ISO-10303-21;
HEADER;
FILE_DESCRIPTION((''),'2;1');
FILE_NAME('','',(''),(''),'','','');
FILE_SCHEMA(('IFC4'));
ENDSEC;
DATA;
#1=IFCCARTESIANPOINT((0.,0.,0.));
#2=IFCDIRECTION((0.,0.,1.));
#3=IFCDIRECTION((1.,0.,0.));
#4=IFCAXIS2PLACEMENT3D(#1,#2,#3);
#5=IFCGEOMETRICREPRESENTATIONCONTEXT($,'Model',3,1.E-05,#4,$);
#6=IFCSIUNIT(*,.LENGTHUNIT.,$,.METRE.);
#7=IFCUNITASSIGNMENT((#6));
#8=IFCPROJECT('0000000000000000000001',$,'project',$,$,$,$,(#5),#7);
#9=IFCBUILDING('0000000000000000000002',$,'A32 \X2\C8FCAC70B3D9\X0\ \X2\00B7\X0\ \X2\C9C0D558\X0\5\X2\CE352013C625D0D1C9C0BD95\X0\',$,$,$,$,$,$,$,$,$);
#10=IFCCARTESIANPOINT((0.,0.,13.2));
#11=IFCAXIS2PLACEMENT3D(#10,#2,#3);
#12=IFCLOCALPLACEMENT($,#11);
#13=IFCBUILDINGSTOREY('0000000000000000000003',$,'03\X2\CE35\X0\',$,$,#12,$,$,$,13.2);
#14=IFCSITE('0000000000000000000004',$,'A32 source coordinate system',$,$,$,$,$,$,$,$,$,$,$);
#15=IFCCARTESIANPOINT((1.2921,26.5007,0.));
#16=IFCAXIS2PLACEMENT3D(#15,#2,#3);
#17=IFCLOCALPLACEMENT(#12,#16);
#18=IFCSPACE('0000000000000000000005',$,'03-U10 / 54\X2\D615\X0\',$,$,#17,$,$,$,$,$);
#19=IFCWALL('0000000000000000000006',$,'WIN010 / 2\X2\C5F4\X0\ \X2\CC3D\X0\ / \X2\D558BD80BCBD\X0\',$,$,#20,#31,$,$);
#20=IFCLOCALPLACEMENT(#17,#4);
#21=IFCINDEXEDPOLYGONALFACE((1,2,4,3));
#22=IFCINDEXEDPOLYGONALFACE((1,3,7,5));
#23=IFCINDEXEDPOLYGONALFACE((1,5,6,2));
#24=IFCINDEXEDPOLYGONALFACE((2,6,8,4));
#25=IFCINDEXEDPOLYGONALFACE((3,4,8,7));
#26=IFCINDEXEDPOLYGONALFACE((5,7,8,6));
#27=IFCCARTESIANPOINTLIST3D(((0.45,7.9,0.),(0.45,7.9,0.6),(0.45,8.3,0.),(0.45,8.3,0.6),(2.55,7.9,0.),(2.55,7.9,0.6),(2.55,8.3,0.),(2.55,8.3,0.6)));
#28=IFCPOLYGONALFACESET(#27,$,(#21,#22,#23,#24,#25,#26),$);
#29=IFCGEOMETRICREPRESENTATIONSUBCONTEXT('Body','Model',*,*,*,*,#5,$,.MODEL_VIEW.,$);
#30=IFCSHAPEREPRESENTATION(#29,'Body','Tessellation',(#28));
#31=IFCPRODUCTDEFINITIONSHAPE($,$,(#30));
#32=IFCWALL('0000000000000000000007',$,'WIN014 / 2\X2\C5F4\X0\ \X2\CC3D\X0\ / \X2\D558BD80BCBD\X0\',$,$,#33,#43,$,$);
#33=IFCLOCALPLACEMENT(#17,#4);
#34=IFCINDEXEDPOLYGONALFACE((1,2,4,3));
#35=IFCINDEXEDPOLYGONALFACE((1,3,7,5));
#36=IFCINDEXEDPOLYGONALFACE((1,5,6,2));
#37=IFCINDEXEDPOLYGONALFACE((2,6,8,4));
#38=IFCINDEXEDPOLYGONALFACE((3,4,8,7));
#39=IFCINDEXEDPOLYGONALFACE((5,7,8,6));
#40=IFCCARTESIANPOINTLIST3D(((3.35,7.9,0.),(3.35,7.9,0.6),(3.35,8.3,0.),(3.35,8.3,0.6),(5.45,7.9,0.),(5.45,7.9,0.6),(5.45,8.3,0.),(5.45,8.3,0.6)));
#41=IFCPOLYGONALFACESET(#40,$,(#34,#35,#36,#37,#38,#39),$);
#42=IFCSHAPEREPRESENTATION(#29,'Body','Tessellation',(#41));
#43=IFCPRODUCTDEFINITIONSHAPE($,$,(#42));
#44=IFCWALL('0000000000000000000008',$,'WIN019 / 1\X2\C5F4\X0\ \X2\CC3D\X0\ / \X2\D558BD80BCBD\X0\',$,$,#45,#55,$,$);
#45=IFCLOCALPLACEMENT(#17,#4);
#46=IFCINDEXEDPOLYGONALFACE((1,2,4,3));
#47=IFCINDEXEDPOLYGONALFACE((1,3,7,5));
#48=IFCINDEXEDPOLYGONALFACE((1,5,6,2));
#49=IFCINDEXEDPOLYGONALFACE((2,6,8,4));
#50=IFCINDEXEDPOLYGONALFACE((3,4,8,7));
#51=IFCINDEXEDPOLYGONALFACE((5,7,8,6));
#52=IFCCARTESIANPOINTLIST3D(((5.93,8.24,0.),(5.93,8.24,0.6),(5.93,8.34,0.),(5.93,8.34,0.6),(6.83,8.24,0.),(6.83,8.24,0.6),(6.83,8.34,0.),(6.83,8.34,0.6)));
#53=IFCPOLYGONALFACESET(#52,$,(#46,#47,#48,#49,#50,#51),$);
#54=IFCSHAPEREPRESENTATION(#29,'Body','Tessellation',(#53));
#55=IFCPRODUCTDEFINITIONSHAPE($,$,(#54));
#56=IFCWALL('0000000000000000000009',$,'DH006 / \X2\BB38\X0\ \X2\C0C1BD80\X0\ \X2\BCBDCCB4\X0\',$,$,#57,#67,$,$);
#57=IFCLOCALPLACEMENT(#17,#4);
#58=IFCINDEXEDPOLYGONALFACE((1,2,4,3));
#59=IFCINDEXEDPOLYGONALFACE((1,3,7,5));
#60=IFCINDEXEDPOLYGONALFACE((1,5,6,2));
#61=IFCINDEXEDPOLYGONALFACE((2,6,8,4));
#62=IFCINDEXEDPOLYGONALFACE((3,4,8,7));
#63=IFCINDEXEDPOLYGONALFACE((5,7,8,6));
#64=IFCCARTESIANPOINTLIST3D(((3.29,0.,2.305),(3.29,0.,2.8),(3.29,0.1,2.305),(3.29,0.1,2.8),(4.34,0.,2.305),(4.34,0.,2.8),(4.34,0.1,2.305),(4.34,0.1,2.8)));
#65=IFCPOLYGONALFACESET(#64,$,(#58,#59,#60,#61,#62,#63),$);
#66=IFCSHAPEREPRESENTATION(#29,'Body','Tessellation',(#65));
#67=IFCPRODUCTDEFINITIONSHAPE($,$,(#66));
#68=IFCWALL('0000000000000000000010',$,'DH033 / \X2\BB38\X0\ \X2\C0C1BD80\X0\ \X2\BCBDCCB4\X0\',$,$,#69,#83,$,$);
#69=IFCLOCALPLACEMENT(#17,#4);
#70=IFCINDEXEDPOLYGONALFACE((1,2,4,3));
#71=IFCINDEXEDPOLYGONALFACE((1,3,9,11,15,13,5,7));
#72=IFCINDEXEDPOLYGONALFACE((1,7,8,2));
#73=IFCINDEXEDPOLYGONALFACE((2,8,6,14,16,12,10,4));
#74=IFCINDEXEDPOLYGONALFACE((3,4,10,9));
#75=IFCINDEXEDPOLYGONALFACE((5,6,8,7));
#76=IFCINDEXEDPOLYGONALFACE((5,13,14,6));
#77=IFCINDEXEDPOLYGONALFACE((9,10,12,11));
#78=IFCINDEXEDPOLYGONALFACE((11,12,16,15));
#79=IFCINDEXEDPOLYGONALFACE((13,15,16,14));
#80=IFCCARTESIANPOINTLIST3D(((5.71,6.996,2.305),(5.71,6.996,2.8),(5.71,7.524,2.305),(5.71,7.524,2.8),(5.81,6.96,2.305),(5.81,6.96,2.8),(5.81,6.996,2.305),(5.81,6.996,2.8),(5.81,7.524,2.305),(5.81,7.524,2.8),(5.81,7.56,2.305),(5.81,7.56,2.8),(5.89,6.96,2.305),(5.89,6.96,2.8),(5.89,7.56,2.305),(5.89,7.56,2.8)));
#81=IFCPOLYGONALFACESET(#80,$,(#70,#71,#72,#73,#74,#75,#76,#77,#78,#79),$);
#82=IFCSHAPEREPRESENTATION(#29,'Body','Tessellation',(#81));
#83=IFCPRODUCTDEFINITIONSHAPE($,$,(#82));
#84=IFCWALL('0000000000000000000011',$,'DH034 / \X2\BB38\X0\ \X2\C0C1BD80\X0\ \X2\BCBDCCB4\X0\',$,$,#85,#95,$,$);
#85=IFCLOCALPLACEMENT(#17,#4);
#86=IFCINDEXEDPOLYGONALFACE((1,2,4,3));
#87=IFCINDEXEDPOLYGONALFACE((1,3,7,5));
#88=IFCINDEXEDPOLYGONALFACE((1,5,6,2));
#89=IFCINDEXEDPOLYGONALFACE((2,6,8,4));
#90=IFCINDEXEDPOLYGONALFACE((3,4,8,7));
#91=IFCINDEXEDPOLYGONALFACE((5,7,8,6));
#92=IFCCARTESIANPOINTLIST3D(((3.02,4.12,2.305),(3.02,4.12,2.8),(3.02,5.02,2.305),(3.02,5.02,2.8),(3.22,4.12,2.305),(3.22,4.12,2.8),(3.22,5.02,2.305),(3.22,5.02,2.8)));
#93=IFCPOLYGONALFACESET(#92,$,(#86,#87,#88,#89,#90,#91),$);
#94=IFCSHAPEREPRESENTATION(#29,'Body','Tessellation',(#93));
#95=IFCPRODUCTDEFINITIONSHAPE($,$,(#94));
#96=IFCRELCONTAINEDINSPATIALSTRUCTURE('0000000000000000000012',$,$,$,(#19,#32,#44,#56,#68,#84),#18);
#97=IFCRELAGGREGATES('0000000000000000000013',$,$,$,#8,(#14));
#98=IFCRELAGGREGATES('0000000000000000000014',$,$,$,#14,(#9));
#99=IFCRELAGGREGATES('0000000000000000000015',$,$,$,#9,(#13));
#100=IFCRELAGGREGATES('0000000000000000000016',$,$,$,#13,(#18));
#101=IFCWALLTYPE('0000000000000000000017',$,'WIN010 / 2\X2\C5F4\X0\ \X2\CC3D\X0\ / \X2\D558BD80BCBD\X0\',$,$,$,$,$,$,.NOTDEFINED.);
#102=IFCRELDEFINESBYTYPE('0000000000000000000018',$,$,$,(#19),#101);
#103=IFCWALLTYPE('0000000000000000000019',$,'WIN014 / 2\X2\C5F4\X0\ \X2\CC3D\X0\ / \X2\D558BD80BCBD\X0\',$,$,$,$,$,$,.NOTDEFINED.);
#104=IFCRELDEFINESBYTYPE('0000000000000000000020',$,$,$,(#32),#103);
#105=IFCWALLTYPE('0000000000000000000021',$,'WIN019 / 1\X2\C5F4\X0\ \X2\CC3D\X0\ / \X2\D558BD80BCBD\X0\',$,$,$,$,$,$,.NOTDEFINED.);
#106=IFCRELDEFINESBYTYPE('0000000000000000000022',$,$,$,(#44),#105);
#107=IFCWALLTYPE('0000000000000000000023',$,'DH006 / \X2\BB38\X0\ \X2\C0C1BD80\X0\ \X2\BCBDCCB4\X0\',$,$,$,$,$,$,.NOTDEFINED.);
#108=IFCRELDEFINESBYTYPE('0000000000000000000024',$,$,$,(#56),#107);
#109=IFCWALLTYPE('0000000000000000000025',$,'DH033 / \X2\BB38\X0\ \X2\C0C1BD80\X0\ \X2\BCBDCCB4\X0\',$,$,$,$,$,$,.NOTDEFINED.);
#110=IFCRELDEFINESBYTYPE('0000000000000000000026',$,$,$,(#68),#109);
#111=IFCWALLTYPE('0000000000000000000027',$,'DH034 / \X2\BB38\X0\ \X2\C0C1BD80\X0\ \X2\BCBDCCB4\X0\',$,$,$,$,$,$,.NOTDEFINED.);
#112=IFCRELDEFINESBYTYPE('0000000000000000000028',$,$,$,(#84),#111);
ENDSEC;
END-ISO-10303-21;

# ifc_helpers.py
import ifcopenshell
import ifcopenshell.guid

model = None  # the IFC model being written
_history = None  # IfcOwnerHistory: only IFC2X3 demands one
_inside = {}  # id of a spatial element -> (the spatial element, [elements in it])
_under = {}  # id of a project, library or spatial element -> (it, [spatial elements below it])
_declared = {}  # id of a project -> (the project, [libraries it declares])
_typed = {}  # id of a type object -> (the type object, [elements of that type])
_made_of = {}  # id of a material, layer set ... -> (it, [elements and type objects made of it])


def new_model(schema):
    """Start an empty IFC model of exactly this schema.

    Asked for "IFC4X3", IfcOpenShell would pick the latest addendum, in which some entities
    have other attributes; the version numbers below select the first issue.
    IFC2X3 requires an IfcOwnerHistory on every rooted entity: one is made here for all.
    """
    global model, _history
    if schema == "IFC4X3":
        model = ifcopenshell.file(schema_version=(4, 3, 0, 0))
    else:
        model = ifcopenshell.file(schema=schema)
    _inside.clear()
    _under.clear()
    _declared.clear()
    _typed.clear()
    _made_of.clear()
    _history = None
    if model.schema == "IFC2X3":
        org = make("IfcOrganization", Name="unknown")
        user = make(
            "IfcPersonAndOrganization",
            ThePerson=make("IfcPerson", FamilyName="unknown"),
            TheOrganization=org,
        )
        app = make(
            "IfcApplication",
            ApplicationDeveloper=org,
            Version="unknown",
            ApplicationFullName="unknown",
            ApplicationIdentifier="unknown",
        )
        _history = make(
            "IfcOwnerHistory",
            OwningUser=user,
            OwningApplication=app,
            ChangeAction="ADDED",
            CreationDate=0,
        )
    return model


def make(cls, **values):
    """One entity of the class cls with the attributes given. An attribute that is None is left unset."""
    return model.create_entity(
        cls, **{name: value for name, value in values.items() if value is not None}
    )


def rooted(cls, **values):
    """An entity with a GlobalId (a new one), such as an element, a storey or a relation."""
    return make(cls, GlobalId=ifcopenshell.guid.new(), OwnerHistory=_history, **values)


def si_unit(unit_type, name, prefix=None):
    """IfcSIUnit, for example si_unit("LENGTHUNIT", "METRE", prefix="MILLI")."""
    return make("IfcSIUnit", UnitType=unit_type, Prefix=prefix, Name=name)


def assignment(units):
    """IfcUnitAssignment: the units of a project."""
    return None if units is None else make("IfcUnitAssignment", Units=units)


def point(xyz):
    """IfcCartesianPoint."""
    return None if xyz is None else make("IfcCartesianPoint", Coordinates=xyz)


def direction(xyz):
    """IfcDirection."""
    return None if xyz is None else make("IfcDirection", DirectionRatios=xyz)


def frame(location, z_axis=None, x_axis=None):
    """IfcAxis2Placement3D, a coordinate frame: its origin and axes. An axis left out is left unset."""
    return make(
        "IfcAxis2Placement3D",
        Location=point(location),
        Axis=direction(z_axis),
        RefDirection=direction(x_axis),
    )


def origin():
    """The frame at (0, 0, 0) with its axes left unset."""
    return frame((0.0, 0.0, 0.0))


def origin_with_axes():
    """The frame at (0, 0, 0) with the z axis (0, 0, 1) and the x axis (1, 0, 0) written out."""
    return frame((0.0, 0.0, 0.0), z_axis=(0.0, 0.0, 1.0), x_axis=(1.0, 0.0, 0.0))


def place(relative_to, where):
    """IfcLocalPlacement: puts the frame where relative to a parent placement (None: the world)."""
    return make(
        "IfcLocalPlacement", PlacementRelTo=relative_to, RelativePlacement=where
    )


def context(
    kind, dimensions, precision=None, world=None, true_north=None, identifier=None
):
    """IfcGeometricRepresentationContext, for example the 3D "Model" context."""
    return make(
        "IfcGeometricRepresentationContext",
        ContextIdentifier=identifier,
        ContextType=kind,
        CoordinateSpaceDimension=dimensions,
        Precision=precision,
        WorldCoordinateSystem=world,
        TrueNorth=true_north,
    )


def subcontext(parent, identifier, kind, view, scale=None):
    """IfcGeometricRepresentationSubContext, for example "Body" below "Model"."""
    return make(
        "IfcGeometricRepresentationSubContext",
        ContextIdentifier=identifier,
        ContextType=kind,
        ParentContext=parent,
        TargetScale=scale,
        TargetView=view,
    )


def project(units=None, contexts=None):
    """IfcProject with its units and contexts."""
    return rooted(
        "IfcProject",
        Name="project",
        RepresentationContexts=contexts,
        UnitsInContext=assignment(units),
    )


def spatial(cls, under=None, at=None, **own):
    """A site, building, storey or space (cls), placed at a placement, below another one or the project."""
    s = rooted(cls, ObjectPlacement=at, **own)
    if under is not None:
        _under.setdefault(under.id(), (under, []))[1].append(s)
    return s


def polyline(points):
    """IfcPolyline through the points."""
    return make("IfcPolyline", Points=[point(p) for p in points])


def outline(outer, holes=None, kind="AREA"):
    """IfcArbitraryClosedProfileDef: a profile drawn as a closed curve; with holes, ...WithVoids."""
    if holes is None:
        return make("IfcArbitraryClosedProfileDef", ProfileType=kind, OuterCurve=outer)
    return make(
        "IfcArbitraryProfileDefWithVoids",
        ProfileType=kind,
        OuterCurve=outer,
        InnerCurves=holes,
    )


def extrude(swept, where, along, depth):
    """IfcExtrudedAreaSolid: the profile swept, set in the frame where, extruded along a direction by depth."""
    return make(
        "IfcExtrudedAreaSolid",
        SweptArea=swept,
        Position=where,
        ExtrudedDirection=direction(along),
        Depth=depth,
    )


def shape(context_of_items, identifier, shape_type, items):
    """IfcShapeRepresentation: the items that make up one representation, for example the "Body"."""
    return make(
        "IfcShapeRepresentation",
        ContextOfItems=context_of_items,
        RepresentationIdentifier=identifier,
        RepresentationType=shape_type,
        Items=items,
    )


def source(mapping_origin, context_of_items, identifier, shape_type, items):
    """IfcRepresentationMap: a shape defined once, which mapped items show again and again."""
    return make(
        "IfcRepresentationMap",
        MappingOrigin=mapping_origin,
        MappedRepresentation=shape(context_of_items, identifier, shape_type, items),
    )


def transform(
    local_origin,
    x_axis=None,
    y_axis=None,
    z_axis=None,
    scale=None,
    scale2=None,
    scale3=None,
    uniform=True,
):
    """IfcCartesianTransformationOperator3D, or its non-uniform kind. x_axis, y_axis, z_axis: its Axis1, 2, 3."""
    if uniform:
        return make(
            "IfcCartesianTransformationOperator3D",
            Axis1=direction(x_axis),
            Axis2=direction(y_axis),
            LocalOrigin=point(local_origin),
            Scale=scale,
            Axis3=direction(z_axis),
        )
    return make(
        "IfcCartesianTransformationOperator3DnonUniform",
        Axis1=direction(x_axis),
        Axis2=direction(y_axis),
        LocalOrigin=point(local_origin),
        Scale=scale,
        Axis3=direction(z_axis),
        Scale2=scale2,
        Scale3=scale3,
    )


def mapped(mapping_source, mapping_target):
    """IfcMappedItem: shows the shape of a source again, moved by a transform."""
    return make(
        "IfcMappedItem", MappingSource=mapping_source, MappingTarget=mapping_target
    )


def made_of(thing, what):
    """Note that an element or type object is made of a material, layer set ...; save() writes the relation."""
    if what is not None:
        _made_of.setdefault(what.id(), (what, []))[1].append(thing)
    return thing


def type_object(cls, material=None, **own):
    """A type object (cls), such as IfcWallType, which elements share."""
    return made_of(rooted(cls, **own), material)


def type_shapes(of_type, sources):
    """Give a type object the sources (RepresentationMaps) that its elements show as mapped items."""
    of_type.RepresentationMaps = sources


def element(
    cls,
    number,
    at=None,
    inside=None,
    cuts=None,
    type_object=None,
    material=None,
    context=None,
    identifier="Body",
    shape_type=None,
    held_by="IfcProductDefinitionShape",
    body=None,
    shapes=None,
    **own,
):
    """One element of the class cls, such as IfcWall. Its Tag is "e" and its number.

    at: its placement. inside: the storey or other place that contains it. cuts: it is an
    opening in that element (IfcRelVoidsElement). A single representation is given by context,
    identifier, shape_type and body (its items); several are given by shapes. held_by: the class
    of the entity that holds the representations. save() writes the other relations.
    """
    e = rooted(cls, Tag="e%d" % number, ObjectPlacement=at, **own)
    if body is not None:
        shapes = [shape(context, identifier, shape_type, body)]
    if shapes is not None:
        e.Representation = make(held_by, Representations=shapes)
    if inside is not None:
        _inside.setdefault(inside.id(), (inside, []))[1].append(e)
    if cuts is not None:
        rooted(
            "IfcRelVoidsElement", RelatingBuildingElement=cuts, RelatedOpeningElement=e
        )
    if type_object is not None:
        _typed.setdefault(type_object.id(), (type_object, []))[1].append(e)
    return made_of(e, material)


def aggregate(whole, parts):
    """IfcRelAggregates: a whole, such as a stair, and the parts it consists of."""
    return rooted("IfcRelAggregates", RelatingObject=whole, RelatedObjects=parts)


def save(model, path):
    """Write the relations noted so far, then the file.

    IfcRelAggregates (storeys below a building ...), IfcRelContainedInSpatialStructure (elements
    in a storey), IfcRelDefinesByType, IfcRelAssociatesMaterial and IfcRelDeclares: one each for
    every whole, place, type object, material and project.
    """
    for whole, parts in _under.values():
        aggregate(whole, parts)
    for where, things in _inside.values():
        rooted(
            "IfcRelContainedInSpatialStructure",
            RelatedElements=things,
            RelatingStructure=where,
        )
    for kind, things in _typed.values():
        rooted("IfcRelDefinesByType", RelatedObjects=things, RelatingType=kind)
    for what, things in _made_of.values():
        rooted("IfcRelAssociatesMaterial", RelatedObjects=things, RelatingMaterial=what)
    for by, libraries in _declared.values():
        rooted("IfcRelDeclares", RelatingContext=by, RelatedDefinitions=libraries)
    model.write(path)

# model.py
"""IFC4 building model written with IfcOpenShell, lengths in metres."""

from ifc_helpers import new_model, si_unit, frame, origin, origin_with_axes, place, context, subcontext, project, spatial, polyline, outline, extrude, source, transform, mapped, type_object, type_shapes, element, save


model = new_model("IFC4")

# Units and contexts
model_context = context("Model", 3, precision=1e-05, world=origin_with_axes())
body_context = subcontext(model_context, "Body", "Model", "MODEL_VIEW")
ifc_project = project(units=[si_unit("LENGTHUNIT", "METRE")], contexts=[model_context])

# Site, building, storey, space
storey_placement = place(None, frame((0.0, 0.0, 13.2), z_axis=(0.0, 0.0, 1.0), x_axis=(1.0, 0.0, 0.0)))
space_placement = place(storey_placement, frame((1.2921, 26.5007, 0.0), z_axis=(0.0, 0.0, 1.0), x_axis=(1.0, 0.0, 0.0)))
site = spatial("IfcSite", under=ifc_project, Name="A32 source coordinate system")
building = spatial("IfcBuilding", under=site, Name="A32 주거동 · 지하5층–옥탑지붕")
storey = spatial("IfcBuildingStorey", under=building, at=storey_placement, Name="03층", Elevation=13.2)
space = spatial("IfcSpace", under=storey, at=space_placement, Name="03-U10 / 54형")

# Walls
wall_type_1 = type_object("IfcWallType", Name="WIN010 / 2열 창 / 하부벽", PredefinedType="NOTDEFINED")
shared_shape_1 = source(origin(), body_context, "Body", "SweptSolid", [
    extrude(outline(polyline([(2.55, 8.3), (2.55, 7.9), (0.45, 7.9), (0.45, 8.3), (2.55, 8.3)])), origin(), (0.0, 0.0, 1.0), 0.6),
])
type_shapes(wall_type_1, [shared_shape_1])
wall_1_placement = place(space_placement, origin_with_axes())
element("IfcWall", 1, at=wall_1_placement, inside=space, type_object=wall_type_1, Name="WIN010 / 2열 창 / 하부벽", context=body_context, shape_type="MappedRepresentation", body=[
    mapped(shared_shape_1, transform((0.0, 0.0, 0.0), scale=1.0)),
])
wall_type_2 = type_object("IfcWallType", Name="WIN014 / 2열 창 / 하부벽", PredefinedType="NOTDEFINED")
shared_shape_2 = source(origin(), body_context, "Body", "SweptSolid", [
    extrude(outline(polyline([(5.45, 8.3), (5.45, 7.9), (3.35, 7.9), (3.35, 8.3), (5.45, 8.3)])), origin(), (0.0, 0.0, 1.0), 0.6),
])
type_shapes(wall_type_2, [shared_shape_2])
wall_2_placement = place(space_placement, origin_with_axes())
element("IfcWall", 2, at=wall_2_placement, inside=space, type_object=wall_type_2, Name="WIN014 / 2열 창 / 하부벽", context=body_context, shape_type="MappedRepresentation", body=[
    mapped(shared_shape_2, transform((0.0, 0.0, 0.0), scale=1.0)),
])
wall_type_3 = type_object("IfcWallType", Name="WIN019 / 1열 창 / 하부벽", PredefinedType="NOTDEFINED")
shared_shape_3 = source(origin(), body_context, "Body", "SweptSolid", [
    extrude(outline(polyline([(6.83, 8.34), (6.83, 8.24), (5.93, 8.24), (5.93, 8.34), (6.83, 8.34)])), origin(), (0.0, 0.0, 1.0), 0.6),
])
type_shapes(wall_type_3, [shared_shape_3])
wall_3_placement = place(space_placement, origin_with_axes())
element("IfcWall", 3, at=wall_3_placement, inside=space, type_object=wall_type_3, Name="WIN019 / 1열 창 / 하부벽", context=body_context, shape_type="MappedRepresentation", body=[
    mapped(shared_shape_3, transform((0.0, 0.0, 0.0), scale=1.0)),
])
wall_type_4 = type_object("IfcWallType", Name="DH006 / 문 상부 벽체", PredefinedType="NOTDEFINED")
shared_shape_4 = source(origin(), body_context, "Body", "SweptSolid", [
    extrude(outline(polyline([(4.34, 0.0), (3.29, 0.0), (3.29, 0.1), (4.34, 0.1), (4.34, 0.0)])), frame((0.0, 0.0, 2.305)), (0.0, 0.0, 1.0), 0.495),
])
type_shapes(wall_type_4, [shared_shape_4])
wall_4_placement = place(space_placement, origin_with_axes())
element("IfcWall", 4, at=wall_4_placement, inside=space, type_object=wall_type_4, Name="DH006 / 문 상부 벽체", context=body_context, shape_type="MappedRepresentation", body=[
    mapped(shared_shape_4, transform((0.0, 0.0, 0.0), scale=1.0)),
])
wall_type_5 = type_object("IfcWallType", Name="DH033 / 문 상부 벽체", PredefinedType="NOTDEFINED")
shared_shape_5 = source(origin(), body_context, "Body", "SweptSolid", [
    extrude(outline(polyline([(5.81, 6.996), (5.71, 6.996), (5.71, 7.524), (5.81, 7.524), (5.81, 7.56), (5.89, 7.56), (5.89, 6.96), (5.81, 6.96), (5.81, 6.996)])), frame((0.0, 0.0, 2.305)), (0.0, 0.0, 1.0), 0.495),
])
type_shapes(wall_type_5, [shared_shape_5])
wall_5_placement = place(space_placement, origin_with_axes())
element("IfcWall", 5, at=wall_5_placement, inside=space, type_object=wall_type_5, Name="DH033 / 문 상부 벽체", context=body_context, shape_type="MappedRepresentation", body=[
    mapped(shared_shape_5, transform((0.0, 0.0, 0.0), scale=1.0)),
])
wall_type_6 = type_object("IfcWallType", Name="DH034 / 문 상부 벽체", PredefinedType="NOTDEFINED")
shared_shape_6 = source(origin(), body_context, "Body", "SweptSolid", [
    extrude(outline(polyline([(3.22, 4.12), (3.02, 4.12), (3.02, 5.02), (3.22, 5.02), (3.22, 4.12)])), frame((0.0, 0.0, 2.305)), (0.0, 0.0, 1.0), 0.495),
])
type_shapes(wall_type_6, [shared_shape_6])
wall_6_placement = place(space_placement, origin_with_axes())
element("IfcWall", 6, at=wall_6_placement, inside=space, type_object=wall_type_6, Name="DH034 / 문 상부 벽체", context=body_context, shape_type="MappedRepresentation", body=[
    mapped(shared_shape_6, transform((0.0, 0.0, 0.0), scale=1.0)),
])

save(model, "model.ifc")
